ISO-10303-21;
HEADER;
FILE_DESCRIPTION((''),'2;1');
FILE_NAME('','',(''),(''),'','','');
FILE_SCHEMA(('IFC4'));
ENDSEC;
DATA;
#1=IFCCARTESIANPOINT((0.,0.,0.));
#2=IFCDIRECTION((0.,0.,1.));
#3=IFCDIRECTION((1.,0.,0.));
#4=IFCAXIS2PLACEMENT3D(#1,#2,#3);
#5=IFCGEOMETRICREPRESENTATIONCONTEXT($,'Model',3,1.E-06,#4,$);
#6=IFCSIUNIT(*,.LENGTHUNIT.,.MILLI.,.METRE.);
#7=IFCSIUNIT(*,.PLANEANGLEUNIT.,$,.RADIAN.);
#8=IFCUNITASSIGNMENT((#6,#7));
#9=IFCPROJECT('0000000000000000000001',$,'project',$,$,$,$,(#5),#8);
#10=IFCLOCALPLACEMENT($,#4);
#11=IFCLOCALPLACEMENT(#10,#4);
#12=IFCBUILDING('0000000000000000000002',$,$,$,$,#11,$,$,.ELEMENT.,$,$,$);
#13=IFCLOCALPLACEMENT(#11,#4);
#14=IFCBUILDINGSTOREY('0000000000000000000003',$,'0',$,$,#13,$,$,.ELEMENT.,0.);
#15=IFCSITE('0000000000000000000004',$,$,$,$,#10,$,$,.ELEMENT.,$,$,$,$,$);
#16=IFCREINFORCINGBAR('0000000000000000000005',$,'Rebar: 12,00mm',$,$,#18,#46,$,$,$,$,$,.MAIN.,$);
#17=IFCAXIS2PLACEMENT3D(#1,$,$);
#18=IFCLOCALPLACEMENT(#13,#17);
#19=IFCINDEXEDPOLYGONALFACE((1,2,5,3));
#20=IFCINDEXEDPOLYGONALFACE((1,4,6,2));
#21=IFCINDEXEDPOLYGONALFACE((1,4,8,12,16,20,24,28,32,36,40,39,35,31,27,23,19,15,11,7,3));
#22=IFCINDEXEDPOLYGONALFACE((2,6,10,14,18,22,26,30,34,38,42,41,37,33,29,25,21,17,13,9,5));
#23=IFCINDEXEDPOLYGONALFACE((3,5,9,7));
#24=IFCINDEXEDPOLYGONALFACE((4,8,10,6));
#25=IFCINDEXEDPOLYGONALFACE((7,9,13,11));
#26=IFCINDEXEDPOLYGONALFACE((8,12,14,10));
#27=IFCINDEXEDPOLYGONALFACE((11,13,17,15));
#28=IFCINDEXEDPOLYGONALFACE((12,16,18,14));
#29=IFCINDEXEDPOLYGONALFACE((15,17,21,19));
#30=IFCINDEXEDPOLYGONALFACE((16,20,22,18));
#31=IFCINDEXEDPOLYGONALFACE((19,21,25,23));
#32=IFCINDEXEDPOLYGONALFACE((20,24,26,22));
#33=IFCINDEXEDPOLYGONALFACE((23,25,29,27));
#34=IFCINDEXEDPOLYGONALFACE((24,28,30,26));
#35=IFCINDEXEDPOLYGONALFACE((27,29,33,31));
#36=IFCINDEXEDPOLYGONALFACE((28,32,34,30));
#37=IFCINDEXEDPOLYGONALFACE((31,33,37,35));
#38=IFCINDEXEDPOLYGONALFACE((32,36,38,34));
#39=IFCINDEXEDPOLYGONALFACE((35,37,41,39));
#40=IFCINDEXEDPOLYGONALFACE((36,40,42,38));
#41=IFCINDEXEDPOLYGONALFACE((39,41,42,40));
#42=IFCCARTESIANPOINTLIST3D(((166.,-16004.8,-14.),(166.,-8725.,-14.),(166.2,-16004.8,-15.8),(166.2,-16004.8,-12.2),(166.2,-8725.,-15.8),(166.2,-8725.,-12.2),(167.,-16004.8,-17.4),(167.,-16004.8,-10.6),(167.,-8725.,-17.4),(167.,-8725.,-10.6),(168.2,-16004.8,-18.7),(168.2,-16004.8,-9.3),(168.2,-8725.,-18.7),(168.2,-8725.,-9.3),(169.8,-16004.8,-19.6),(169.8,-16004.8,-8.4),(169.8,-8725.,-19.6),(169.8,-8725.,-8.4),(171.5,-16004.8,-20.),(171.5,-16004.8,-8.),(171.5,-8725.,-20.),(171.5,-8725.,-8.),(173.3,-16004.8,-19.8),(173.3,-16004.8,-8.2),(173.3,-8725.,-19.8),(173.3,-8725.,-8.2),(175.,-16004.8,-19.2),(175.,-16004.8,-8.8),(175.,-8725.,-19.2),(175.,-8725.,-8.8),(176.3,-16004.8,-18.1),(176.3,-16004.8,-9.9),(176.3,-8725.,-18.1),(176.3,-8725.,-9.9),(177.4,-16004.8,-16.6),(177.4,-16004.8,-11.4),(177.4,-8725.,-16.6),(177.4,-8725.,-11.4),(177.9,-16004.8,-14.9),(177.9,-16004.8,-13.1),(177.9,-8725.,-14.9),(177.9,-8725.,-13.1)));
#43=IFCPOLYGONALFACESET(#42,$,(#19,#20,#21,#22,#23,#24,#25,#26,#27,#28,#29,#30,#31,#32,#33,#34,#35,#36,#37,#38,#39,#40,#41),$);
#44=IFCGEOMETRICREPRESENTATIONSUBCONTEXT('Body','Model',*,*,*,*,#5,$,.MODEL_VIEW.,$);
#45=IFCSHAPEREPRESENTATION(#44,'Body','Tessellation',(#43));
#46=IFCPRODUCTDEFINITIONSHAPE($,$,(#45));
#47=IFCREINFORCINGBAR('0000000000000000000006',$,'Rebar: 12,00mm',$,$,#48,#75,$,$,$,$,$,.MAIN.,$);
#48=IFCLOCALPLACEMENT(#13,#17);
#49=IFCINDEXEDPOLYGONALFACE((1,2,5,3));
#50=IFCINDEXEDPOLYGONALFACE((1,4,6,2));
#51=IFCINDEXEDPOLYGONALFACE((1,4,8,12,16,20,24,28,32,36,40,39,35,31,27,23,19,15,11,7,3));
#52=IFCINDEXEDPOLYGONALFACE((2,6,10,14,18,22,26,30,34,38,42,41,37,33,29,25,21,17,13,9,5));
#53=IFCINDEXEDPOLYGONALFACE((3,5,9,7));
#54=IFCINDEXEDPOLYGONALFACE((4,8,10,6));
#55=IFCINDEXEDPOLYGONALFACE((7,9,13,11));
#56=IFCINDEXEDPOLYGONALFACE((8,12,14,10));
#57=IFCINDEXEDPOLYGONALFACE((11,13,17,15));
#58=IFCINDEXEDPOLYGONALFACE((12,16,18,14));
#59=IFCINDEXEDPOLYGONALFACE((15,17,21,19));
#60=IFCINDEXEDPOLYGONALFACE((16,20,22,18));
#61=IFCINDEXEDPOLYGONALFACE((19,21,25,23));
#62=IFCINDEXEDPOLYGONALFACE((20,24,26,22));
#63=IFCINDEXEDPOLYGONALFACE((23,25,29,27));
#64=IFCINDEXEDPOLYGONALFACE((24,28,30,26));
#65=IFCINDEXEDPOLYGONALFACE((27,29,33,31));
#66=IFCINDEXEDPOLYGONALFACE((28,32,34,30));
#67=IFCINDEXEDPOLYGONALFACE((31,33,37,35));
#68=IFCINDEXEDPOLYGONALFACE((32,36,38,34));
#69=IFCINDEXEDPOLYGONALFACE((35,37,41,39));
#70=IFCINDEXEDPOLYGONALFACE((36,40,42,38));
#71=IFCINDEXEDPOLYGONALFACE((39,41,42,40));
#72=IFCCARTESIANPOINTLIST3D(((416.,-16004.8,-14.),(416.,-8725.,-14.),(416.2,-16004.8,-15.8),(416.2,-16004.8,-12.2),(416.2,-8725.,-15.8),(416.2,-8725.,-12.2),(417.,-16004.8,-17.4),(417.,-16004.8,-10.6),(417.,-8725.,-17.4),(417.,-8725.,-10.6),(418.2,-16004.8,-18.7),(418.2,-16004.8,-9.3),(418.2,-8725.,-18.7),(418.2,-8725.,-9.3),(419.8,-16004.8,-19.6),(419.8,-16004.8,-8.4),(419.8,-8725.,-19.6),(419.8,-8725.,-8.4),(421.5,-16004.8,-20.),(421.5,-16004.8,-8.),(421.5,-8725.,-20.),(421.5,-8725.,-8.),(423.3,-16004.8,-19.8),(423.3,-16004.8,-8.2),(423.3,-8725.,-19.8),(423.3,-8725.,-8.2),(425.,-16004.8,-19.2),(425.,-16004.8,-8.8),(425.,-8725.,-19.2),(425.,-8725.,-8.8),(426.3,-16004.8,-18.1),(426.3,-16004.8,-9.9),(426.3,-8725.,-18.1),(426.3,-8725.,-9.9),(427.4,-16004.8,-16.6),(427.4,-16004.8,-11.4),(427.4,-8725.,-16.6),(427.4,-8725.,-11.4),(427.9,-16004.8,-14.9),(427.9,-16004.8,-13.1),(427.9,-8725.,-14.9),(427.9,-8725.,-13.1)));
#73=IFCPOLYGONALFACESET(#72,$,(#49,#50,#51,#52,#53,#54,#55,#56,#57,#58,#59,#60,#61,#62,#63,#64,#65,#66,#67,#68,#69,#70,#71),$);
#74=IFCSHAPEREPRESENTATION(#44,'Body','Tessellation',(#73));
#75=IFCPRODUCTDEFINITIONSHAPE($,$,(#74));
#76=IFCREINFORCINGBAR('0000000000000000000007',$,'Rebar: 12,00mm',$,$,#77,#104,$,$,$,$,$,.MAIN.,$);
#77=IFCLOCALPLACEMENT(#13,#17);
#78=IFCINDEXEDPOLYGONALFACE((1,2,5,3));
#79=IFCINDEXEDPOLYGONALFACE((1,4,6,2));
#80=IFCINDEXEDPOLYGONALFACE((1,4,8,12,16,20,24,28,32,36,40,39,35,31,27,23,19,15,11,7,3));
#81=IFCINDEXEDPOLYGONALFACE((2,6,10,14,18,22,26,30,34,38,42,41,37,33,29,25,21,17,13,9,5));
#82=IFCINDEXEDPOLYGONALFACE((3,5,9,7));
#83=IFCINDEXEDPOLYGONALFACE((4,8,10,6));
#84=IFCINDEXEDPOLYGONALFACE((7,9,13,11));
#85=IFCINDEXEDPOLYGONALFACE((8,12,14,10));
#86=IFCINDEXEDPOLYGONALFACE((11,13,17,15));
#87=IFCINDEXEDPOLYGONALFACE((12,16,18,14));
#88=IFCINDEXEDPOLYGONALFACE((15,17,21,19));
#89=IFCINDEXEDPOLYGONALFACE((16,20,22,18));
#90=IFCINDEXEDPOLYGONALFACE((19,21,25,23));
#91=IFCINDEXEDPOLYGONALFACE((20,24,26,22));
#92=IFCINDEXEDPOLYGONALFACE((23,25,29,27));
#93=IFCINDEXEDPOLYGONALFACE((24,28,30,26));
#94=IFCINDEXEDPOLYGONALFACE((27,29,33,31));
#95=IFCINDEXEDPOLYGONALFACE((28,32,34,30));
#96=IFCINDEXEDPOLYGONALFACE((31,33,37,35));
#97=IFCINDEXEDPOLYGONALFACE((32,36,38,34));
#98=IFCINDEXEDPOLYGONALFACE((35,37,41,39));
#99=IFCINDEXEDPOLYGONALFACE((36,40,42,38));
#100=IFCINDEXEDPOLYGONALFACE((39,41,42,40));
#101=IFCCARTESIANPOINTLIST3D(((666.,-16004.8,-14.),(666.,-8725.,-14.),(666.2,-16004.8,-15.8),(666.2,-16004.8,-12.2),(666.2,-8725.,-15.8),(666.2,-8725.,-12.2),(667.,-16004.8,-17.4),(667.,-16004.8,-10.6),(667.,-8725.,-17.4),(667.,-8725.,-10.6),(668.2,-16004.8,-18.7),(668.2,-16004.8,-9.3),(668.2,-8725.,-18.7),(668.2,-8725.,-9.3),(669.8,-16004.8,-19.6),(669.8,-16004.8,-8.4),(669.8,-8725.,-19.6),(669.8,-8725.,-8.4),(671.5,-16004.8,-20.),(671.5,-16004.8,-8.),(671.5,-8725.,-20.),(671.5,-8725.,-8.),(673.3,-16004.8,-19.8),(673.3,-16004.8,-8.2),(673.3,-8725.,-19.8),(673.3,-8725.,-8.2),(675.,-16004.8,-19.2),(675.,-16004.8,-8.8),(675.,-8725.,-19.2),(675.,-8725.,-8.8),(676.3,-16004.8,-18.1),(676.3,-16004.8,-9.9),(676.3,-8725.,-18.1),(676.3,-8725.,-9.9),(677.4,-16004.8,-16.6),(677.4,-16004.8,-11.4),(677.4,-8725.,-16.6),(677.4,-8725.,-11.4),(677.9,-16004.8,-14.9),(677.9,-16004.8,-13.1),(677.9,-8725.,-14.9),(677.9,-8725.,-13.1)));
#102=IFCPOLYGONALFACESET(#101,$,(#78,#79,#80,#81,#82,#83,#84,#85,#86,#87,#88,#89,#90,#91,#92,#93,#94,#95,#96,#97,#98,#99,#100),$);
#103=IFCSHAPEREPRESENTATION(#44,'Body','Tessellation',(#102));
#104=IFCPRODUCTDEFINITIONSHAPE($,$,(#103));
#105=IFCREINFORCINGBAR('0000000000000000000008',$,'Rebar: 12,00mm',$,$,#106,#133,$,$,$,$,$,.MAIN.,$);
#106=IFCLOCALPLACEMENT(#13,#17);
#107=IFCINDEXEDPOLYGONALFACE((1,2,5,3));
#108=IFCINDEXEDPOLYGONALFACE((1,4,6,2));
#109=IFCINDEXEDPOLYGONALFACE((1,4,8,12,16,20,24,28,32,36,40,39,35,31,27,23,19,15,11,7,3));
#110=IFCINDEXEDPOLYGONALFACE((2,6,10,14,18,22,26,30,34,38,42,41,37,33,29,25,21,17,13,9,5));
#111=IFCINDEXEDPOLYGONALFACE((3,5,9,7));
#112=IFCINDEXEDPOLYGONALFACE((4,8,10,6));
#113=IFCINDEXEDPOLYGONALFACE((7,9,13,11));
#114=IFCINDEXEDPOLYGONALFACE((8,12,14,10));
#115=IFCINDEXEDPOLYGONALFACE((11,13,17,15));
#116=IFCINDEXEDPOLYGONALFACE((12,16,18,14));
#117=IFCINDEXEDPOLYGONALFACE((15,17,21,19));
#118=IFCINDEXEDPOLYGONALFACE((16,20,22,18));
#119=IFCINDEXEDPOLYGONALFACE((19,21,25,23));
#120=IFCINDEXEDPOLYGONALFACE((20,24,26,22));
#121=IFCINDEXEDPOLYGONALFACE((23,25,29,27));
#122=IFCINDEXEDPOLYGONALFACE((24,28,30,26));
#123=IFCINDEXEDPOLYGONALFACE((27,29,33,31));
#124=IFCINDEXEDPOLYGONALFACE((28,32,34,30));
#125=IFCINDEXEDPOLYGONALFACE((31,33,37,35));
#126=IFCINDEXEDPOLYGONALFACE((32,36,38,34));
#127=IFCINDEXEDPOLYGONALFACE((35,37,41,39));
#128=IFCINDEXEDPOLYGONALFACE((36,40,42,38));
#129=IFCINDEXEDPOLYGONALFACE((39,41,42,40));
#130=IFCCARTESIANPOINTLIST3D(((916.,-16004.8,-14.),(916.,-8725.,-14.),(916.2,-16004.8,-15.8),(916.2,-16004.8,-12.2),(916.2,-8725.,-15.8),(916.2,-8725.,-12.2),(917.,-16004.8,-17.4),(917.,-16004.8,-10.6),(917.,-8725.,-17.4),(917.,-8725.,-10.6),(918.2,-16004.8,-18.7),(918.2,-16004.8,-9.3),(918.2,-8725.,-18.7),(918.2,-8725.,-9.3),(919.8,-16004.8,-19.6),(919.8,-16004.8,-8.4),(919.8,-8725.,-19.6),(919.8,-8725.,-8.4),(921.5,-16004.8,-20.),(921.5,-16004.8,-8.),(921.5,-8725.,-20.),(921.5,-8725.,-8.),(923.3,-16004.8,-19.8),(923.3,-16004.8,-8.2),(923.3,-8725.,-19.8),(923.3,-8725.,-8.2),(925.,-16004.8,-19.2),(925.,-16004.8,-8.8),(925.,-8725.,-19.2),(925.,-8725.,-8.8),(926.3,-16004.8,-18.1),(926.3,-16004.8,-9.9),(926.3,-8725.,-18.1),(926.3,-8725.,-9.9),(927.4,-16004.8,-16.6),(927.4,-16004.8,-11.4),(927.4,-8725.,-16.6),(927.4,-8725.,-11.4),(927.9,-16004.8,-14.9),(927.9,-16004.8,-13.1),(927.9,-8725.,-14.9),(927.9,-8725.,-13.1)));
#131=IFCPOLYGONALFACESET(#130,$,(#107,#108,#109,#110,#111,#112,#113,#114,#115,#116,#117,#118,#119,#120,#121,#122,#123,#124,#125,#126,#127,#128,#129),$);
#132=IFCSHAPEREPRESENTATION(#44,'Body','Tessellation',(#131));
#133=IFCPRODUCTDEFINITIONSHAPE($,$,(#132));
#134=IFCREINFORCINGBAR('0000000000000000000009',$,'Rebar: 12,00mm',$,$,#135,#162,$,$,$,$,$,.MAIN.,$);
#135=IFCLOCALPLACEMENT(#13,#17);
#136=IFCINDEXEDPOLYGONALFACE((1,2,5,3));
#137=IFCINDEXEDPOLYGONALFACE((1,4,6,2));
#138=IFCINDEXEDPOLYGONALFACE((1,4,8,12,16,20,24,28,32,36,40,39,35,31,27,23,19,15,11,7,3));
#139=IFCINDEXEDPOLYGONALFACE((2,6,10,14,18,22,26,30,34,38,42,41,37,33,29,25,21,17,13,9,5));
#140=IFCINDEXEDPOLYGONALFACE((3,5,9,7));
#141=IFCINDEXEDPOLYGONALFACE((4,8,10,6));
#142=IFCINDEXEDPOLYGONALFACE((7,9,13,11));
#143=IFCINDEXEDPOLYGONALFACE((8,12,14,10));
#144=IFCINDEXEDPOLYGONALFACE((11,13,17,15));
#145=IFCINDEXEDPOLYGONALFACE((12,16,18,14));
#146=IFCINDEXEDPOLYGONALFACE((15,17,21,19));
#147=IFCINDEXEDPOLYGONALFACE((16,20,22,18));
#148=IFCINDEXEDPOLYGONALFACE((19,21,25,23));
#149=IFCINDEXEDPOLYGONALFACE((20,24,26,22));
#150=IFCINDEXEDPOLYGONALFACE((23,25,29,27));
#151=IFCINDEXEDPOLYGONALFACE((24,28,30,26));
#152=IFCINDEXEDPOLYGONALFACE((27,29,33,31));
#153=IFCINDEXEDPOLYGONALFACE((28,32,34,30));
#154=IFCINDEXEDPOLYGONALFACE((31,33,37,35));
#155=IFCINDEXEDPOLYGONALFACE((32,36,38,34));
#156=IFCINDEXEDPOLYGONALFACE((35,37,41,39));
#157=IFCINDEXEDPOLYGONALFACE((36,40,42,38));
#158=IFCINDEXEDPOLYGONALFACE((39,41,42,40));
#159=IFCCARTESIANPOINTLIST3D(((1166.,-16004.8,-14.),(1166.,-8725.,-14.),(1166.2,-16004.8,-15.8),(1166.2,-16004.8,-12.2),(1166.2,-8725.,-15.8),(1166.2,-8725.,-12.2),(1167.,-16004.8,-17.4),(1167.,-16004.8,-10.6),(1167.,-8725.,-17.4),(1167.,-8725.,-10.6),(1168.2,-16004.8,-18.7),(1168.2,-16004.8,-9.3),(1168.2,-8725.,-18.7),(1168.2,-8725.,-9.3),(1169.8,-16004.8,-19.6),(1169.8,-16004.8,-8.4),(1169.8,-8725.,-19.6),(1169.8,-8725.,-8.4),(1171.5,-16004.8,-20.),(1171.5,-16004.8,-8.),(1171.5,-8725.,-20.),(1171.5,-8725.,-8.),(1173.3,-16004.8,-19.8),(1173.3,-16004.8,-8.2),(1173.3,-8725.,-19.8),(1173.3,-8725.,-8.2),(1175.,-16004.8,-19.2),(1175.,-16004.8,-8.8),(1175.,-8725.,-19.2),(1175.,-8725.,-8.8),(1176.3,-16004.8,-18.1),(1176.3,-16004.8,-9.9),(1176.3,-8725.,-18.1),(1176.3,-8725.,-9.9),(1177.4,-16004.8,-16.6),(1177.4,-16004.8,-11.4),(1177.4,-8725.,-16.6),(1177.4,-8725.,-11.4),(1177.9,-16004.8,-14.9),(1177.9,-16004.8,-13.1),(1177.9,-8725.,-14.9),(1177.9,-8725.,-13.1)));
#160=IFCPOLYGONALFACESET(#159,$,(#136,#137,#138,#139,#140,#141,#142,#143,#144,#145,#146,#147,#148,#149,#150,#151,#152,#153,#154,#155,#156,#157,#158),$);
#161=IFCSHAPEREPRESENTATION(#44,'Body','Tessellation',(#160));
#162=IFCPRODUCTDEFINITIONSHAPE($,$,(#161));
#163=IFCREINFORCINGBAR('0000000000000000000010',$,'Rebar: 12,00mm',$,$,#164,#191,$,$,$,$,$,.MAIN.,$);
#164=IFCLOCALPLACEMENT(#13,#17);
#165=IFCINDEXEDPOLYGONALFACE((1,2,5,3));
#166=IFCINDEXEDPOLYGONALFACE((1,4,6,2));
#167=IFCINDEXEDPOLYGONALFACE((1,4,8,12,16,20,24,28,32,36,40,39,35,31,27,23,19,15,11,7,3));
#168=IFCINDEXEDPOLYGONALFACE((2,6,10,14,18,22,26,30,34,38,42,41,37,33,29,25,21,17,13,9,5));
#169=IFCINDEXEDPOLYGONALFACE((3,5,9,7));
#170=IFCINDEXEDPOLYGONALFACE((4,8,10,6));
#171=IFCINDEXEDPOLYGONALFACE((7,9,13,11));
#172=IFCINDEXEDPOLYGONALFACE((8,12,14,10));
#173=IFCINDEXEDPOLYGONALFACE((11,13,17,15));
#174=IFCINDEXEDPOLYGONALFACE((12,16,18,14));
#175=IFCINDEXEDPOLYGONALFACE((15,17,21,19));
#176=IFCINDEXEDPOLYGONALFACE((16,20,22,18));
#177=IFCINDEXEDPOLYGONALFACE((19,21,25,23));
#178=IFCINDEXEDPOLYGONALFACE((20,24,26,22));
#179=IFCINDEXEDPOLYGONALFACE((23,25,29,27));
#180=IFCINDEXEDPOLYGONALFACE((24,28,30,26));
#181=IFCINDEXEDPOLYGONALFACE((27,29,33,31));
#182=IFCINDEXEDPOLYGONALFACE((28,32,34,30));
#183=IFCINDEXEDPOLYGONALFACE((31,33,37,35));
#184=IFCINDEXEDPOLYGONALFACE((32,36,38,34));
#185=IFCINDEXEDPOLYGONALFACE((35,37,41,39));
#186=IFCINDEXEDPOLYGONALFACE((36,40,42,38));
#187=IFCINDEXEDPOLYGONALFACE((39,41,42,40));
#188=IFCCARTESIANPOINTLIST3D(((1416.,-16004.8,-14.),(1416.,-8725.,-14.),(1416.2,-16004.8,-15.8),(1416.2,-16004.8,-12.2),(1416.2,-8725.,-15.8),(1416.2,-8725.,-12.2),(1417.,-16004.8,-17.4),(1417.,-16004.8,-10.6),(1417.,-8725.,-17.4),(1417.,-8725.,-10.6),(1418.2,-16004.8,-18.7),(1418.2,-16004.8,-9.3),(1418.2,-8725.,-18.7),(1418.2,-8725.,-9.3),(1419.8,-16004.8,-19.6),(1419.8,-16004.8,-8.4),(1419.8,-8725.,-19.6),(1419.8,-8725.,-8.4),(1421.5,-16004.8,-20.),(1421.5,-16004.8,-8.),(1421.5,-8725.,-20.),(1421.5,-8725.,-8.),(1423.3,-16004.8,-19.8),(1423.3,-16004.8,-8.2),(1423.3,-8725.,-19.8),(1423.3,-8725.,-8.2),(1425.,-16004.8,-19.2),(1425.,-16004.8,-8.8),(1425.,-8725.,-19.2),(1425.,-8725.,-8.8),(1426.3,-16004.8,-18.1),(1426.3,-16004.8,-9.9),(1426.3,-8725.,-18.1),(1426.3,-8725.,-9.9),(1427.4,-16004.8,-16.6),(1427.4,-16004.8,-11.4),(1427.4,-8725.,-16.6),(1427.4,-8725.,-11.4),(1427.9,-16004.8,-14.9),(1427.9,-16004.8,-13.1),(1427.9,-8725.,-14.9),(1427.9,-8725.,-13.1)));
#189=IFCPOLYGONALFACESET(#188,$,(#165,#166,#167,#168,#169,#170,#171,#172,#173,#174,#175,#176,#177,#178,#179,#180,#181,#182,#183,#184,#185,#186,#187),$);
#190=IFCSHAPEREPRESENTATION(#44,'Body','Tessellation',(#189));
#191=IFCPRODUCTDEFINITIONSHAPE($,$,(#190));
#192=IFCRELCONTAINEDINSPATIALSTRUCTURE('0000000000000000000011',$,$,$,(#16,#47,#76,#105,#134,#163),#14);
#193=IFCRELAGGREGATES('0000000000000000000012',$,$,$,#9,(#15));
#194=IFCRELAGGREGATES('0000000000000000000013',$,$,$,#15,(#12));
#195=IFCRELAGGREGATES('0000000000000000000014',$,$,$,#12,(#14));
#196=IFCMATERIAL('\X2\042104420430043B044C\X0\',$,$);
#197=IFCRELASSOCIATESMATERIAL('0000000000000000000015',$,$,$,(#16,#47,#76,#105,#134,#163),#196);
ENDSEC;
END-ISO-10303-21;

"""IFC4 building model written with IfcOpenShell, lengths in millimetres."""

from ifc_helpers import new_model, entity, si_unit, origin_with_axes, place, context, subcontext, project, spatial, source, transform, mapped, material, element, save


model = new_model("IFC4")

# Units and contexts
model_context = context("Model", 3, precision=1e-06, world=origin_with_axes())
body_context = subcontext(model_context, "Body", "Model", "MODEL_VIEW")
ifc_project = project(units=[si_unit("LENGTHUNIT", "METRE", prefix="MILLI"), si_unit("PLANEANGLEUNIT", "RADIAN")], contexts=[model_context])

# Site, building, storey
site_placement = place(None, origin_with_axes())
site = spatial("IfcSite", under=ifc_project, at=site_placement, CompositionType="ELEMENT")
building_placement = place(site_placement, origin_with_axes())
building = spatial("IfcBuilding", under=site, at=building_placement, CompositionType="ELEMENT")
storey_placement = place(building_placement, origin_with_axes())
storey = spatial("IfcBuildingStorey", under=building, at=storey_placement, Name="0", CompositionType="ELEMENT", Elevation=0.0)

# Reinforcing bars
ifc_material = material(Name="Сталь")
shared_shape = source(origin_with_axes(), body_context, "Body", "AdvancedSweptSolid", [
    entity("IfcSweptDiskSolid", entity("IfcIndexedPolyCurve", entity("IfcCartesianPointList3D", [[0.0, 0.0, 0.0], [7279.8, 0.0, 0.0]]), [entity("IfcLineIndex", [1, 2])]), 6.0),
])
reinforcing_bar_1_placement = place(storey_placement, origin_with_axes())
element("IfcReinforcingBar", 1, at=reinforcing_bar_1_placement, inside=storey, material=ifc_material, Name="Rebar: 12,00mm", PredefinedType="MAIN", context=body_context, shape_type="MappedRepresentation", body=[
    mapped(shared_shape, transform((172.0, -16004.8, -14.0), x_axis=(0.0, 1.0, 0.0), y_axis=(-1.0, 0.0, 0.0), z_axis=(0.0, 0.0, 1.0), scale=1.0)),
])
reinforcing_bar_2_placement = place(storey_placement, origin_with_axes())
element("IfcReinforcingBar", 2, at=reinforcing_bar_2_placement, inside=storey, material=ifc_material, Name="Rebar: 12,00mm", PredefinedType="MAIN", context=body_context, shape_type="MappedRepresentation", body=[
    mapped(shared_shape, transform((422.0, -16004.8, -14.0), x_axis=(0.0, 1.0, 0.0), y_axis=(-1.0, 0.0, 0.0), z_axis=(0.0, 0.0, 1.0), scale=1.0)),
])
reinforcing_bar_3_placement = place(storey_placement, origin_with_axes())
element("IfcReinforcingBar", 3, at=reinforcing_bar_3_placement, inside=storey, material=ifc_material, Name="Rebar: 12,00mm", PredefinedType="MAIN", context=body_context, shape_type="MappedRepresentation", body=[
    mapped(shared_shape, transform((672.0, -16004.8, -14.0), x_axis=(0.0, 1.0, 0.0), y_axis=(-1.0, 0.0, 0.0), z_axis=(0.0, 0.0, 1.0), scale=1.0)),
])
reinforcing_bar_4_placement = place(storey_placement, origin_with_axes())
element("IfcReinforcingBar", 4, at=reinforcing_bar_4_placement, inside=storey, material=ifc_material, Name="Rebar: 12,00mm", PredefinedType="MAIN", context=body_context, shape_type="MappedRepresentation", body=[
    mapped(shared_shape, transform((922.0, -16004.8, -14.0), x_axis=(0.0, 1.0, 0.0), y_axis=(-1.0, 0.0, 0.0), z_axis=(0.0, 0.0, 1.0), scale=1.0)),
])
reinforcing_bar_5_placement = place(storey_placement, origin_with_axes())
element("IfcReinforcingBar", 5, at=reinforcing_bar_5_placement, inside=storey, material=ifc_material, Name="Rebar: 12,00mm", PredefinedType="MAIN", context=body_context, shape_type="MappedRepresentation", body=[
    mapped(shared_shape, transform((1172.0, -16004.8, -14.0), x_axis=(0.0, 1.0, 0.0), y_axis=(-1.0, 0.0, 0.0), z_axis=(0.0, 0.0, 1.0), scale=1.0)),
])
reinforcing_bar_6_placement = place(storey_placement, origin_with_axes())
element("IfcReinforcingBar", 6, at=reinforcing_bar_6_placement, inside=storey, material=ifc_material, Name="Rebar: 12,00mm", PredefinedType="MAIN", context=body_context, shape_type="MappedRepresentation", body=[
    mapped(shared_shape, transform((1422.0, -16004.8, -14.0), x_axis=(0.0, 1.0, 0.0), y_axis=(-1.0, 0.0, 0.0), z_axis=(0.0, 0.0, 1.0), scale=1.0)),
])

save(model, "model.ifc")
